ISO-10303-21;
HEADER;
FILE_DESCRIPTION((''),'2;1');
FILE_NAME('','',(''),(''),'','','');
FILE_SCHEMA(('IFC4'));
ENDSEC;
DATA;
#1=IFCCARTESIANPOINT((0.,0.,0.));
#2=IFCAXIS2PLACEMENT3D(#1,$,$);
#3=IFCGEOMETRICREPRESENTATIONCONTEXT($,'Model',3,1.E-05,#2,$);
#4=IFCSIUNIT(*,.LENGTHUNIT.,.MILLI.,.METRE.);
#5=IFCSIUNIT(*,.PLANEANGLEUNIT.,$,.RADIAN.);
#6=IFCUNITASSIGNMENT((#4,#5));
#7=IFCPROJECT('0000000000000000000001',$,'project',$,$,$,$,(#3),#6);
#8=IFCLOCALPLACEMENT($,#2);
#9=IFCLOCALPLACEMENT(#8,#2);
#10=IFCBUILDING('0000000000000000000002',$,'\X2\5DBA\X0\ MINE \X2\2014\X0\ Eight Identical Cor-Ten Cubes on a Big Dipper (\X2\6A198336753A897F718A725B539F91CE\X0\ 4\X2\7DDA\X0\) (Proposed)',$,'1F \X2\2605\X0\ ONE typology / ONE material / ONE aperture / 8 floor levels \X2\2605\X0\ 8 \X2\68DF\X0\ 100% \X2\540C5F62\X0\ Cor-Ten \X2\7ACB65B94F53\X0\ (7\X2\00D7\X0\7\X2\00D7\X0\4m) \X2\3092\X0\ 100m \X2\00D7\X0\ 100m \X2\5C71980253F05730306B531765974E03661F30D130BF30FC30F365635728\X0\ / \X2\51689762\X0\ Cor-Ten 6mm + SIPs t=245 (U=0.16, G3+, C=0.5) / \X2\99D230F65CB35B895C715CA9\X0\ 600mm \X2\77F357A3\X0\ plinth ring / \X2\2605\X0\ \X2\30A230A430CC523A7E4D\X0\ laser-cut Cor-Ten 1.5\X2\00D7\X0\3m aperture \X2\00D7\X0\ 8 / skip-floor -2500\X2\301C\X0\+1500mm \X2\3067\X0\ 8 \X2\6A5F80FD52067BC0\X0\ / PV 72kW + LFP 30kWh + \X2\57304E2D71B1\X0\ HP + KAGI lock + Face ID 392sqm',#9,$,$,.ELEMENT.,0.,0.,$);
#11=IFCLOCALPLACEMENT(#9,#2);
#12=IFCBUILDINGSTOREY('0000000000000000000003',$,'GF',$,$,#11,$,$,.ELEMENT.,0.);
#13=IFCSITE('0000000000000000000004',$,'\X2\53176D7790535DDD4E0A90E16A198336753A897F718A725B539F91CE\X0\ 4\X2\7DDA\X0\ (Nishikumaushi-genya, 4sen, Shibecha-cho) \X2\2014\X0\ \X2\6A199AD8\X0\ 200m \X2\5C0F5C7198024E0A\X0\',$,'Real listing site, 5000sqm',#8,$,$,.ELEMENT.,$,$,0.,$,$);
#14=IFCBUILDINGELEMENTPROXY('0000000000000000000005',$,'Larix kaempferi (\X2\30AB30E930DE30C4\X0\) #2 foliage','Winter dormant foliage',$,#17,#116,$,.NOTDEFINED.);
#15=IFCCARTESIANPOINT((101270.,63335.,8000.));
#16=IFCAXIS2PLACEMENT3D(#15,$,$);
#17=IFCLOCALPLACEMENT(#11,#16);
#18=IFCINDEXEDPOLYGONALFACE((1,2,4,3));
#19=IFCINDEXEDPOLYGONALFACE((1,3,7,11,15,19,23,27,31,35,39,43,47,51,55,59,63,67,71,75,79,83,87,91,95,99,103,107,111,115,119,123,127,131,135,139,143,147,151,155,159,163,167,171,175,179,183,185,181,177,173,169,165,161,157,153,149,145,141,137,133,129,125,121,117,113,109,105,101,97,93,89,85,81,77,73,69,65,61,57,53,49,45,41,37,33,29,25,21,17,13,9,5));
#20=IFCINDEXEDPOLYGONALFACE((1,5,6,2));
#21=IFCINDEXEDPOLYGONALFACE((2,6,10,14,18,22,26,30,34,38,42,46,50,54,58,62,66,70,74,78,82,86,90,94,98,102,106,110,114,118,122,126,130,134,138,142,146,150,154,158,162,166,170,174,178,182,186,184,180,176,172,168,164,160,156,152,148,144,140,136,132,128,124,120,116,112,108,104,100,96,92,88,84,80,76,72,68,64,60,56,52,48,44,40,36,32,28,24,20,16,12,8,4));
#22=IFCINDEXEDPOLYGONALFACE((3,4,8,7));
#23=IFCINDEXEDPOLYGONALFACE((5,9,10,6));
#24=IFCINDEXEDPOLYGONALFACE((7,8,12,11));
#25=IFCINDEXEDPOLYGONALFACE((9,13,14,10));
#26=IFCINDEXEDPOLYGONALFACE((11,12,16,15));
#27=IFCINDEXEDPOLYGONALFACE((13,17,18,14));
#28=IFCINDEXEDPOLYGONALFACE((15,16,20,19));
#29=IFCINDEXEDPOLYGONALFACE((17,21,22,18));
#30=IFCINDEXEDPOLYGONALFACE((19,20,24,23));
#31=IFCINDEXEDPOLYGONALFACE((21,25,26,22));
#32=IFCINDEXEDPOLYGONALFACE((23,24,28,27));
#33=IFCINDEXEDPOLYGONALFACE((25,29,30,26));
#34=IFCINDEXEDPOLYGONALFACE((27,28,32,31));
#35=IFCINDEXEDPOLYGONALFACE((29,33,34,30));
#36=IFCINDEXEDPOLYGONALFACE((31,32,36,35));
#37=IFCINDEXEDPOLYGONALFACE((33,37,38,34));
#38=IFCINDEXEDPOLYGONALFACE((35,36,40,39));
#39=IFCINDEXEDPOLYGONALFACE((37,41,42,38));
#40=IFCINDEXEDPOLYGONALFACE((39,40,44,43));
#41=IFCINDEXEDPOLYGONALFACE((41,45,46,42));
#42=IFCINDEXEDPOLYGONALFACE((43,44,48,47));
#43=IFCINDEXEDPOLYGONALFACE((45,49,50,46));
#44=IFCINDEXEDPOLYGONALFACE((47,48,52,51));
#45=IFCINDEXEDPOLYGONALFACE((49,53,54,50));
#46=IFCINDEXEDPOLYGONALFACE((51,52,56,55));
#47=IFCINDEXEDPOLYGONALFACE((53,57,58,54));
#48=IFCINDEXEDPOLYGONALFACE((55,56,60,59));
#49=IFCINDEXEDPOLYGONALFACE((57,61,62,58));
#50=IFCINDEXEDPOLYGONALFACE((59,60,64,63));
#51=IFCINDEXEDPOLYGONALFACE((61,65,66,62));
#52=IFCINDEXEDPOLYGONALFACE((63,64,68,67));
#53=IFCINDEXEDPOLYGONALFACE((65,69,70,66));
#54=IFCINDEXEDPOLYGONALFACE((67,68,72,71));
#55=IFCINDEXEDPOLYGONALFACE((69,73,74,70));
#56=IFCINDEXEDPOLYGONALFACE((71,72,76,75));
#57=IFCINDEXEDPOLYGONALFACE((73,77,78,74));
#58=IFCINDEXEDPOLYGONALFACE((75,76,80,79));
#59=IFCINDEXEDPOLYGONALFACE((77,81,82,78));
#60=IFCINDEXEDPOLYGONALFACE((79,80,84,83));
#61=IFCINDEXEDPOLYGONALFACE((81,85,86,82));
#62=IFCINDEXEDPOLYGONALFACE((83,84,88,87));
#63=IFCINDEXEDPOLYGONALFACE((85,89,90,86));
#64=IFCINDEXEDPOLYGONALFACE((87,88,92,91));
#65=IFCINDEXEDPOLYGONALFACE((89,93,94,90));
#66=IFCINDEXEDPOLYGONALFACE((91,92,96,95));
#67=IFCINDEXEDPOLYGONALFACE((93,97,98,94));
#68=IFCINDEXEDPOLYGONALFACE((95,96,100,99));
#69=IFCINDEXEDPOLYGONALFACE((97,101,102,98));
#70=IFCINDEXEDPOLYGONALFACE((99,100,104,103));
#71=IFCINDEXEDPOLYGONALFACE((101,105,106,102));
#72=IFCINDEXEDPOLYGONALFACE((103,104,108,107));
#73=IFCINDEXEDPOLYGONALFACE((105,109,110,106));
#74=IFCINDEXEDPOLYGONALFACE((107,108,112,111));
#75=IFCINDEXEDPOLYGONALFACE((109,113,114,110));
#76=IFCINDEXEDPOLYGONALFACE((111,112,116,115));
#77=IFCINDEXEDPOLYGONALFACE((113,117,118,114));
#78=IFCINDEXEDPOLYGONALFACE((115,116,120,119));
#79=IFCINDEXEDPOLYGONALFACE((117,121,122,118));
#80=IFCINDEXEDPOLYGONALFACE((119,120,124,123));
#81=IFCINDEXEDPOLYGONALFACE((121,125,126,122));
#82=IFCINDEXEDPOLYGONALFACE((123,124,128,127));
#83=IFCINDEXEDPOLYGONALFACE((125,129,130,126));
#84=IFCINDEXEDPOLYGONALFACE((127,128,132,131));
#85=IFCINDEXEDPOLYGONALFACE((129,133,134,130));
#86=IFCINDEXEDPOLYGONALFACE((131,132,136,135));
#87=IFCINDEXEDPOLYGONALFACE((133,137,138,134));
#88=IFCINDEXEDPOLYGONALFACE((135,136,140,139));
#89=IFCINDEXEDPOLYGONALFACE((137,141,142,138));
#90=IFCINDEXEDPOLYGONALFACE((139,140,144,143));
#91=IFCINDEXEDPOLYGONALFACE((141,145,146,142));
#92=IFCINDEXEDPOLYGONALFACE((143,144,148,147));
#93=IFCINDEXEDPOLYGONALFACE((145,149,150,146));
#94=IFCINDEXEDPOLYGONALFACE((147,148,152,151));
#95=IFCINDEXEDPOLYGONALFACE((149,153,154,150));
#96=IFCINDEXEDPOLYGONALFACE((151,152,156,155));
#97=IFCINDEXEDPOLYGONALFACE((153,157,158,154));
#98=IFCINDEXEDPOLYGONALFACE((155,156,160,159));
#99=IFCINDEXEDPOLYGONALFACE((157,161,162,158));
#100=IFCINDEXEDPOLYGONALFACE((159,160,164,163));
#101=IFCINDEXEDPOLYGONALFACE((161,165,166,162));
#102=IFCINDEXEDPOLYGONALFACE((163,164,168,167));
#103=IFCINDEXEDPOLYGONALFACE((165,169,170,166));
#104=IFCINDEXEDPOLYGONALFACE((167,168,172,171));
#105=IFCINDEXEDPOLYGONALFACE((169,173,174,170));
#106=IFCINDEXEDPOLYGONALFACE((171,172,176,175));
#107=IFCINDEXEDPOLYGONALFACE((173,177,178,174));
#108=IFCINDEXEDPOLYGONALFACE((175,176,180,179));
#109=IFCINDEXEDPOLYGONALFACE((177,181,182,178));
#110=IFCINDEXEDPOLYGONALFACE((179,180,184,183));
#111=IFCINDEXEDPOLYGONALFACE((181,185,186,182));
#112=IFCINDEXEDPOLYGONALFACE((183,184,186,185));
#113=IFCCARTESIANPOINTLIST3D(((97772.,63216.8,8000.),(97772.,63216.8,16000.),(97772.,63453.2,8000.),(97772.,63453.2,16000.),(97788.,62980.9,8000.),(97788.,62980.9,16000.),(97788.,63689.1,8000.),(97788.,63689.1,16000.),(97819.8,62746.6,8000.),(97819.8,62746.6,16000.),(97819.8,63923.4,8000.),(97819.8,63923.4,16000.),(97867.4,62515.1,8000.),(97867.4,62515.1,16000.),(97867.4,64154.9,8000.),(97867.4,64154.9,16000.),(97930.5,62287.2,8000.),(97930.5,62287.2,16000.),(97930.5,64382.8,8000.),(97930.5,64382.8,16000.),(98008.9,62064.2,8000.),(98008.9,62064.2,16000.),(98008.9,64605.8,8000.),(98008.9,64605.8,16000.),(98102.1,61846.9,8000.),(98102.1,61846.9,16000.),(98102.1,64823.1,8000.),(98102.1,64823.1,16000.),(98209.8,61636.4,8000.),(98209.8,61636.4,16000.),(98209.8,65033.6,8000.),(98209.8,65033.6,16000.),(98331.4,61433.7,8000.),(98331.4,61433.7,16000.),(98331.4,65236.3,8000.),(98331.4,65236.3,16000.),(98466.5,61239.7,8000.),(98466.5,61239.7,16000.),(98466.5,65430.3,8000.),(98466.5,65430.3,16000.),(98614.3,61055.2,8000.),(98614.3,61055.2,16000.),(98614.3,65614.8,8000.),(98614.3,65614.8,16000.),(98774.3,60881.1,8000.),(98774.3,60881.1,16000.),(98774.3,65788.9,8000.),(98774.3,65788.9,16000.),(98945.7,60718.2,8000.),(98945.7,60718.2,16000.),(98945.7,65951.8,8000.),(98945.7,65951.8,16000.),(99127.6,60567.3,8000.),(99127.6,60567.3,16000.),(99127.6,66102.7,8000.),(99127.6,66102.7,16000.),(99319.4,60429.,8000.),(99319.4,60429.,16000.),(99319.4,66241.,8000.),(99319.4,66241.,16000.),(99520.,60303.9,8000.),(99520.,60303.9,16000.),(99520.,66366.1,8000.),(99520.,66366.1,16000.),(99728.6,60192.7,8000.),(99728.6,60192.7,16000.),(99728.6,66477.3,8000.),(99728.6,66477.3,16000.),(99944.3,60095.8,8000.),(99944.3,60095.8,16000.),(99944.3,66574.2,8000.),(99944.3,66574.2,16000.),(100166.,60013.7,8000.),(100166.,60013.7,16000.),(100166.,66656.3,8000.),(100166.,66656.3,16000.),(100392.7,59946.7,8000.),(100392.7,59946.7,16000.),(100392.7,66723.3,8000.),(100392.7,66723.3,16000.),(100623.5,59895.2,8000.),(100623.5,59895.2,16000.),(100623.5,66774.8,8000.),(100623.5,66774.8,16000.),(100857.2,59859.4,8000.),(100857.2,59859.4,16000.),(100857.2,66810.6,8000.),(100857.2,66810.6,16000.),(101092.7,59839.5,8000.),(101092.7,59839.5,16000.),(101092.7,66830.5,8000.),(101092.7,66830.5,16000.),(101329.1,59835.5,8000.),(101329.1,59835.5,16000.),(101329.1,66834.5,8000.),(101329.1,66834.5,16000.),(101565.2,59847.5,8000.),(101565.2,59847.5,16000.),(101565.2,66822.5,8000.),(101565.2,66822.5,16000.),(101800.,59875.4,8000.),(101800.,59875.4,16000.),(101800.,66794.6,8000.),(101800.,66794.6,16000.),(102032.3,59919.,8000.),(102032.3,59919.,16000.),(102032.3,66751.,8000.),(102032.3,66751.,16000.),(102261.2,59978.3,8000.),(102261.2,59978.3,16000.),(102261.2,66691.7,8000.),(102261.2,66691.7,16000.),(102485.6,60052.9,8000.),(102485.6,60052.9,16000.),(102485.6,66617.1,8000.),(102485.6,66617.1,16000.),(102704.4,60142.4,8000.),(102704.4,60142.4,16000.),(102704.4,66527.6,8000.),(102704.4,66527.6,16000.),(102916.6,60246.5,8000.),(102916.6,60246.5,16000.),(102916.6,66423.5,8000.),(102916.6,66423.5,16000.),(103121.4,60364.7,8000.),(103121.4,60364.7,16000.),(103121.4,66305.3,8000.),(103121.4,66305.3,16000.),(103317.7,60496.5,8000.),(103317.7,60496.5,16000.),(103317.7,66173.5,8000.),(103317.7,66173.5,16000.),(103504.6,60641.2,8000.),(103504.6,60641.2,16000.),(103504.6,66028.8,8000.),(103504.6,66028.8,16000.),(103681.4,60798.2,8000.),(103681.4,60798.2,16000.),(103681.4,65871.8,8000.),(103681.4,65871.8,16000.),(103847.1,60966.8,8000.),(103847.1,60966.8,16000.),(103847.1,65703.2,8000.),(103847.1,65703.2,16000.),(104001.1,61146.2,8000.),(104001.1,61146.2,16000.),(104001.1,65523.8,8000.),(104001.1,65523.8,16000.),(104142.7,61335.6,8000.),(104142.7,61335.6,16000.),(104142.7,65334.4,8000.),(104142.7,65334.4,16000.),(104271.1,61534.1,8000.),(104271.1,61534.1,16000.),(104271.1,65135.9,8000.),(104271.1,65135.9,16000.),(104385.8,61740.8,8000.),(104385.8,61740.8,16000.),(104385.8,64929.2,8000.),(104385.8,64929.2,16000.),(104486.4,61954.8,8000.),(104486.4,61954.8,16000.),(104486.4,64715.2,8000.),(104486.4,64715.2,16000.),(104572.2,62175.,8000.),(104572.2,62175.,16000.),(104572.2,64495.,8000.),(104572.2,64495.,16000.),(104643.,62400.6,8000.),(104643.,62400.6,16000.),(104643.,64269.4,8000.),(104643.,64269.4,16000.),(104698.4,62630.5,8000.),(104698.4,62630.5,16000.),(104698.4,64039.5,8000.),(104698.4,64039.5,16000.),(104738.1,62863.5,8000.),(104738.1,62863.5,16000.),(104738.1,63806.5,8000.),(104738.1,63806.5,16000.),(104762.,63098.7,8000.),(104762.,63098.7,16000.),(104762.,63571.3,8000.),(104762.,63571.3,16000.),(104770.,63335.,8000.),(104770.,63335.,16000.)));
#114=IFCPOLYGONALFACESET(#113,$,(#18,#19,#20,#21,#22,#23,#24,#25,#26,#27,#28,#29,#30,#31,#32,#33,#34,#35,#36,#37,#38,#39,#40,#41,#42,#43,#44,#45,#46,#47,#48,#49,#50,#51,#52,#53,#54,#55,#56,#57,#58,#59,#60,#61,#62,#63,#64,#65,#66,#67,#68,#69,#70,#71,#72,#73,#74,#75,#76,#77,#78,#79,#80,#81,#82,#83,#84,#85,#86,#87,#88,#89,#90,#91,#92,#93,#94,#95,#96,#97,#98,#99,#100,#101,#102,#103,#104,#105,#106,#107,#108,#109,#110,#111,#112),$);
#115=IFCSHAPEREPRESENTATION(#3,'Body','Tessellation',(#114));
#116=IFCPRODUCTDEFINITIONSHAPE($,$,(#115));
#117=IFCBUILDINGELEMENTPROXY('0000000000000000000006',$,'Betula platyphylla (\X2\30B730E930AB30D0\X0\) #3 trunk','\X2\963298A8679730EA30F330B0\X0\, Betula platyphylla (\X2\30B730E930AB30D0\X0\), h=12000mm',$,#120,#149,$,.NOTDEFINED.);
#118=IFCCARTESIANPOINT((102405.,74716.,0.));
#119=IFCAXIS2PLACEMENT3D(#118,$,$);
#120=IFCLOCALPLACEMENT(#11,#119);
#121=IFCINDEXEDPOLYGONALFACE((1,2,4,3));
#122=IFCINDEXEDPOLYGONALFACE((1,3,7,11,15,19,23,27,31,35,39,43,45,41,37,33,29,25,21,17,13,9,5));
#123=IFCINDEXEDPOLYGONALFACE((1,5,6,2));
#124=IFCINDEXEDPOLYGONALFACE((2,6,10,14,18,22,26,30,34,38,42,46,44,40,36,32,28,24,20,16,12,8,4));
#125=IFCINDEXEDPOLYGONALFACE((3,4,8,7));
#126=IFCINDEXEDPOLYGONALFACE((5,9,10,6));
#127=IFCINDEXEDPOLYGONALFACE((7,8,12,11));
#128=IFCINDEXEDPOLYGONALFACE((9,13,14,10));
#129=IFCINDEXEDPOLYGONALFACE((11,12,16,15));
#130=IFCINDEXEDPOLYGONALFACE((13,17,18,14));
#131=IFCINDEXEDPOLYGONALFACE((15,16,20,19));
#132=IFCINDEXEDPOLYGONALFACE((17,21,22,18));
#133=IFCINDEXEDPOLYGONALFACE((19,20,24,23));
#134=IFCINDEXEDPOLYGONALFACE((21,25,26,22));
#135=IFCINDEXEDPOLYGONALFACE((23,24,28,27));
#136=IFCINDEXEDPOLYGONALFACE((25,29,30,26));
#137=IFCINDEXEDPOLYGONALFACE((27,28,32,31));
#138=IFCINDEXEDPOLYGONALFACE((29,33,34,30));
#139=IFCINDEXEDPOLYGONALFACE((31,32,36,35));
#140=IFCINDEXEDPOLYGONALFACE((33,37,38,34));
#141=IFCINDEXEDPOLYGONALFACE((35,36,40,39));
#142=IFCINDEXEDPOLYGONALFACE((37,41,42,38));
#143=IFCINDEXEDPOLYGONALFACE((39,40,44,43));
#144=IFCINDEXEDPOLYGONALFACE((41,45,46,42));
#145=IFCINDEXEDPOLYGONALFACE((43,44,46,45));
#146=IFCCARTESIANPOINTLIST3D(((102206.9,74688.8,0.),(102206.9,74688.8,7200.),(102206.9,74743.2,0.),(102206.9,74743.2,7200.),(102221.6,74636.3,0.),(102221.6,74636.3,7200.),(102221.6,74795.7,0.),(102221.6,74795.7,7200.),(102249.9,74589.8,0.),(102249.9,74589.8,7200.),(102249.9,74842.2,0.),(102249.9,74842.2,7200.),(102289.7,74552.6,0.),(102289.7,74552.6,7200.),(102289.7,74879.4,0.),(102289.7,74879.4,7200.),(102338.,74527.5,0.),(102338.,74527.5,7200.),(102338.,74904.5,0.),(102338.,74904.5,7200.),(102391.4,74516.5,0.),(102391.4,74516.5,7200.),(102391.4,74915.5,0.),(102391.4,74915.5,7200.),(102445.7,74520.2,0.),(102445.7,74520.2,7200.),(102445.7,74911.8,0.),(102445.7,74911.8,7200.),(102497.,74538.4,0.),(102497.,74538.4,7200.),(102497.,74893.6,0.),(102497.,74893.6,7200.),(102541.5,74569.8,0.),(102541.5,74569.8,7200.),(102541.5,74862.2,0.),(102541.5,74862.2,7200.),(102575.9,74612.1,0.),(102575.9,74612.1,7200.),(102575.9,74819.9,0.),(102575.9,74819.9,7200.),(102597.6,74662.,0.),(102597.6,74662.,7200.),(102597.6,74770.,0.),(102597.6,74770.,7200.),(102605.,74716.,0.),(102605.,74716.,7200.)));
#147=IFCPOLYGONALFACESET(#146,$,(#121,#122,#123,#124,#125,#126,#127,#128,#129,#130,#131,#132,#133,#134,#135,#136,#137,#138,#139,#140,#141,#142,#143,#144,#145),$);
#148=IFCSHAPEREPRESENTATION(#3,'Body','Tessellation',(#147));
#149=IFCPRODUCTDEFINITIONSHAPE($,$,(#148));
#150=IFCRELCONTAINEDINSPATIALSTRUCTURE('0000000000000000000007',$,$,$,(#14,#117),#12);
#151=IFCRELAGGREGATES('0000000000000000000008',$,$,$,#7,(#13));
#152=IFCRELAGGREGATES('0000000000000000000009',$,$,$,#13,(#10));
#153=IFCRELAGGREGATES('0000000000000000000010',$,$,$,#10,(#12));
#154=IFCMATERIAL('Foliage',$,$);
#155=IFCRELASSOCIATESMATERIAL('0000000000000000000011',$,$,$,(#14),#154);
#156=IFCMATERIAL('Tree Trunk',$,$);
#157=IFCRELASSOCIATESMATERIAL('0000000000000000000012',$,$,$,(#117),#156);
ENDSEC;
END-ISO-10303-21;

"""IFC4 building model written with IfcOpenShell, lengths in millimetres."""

from ifc_helpers import new_model, si_unit, frame, origin, origin_2d, place, context, project, spatial, circle, extrude, material, element, save


model = new_model("IFC4")

# Units and contexts
model_context = context("Model", 3, precision=1e-05, world=origin())
ifc_project = project(units=[si_unit("LENGTHUNIT", "METRE", prefix="MILLI"), si_unit("PLANEANGLEUNIT", "RADIAN")], contexts=[model_context])

# Site, building, storey
site_placement = place(None, origin())
site = spatial("IfcSite", under=ifc_project, at=site_placement, Name="北海道川上郡標茶町西熊牛原野 4線 (Nishikumaushi-genya, 4sen, Shibecha-cho) — 標高 200m 小山頂上", ObjectType="Real listing site, 5000sqm", CompositionType="ELEMENT", RefElevation=0.0)
building_placement = place(site_placement, origin())
building = spatial("IfcBuilding", under=site, at=building_placement, Name="嶺 MINE — Eight Identical Cor-Ten Cubes on a Big Dipper (標茶町西熊牛原野 4線) (Proposed)", ObjectType="1F ★ ONE typology / ONE material / ONE aperture / 8 floor levels ★ 8 棟 100% 同形 Cor-Ten 立方体 (7×7×4m) を 100m × 100m 山頂台地に北斗七星パターン散在 / 全面 Cor-Ten 6mm + SIPs t=245 (U=0.16, G3+, C=0.5) / 駒ヶ岳安山岩 600mm 石垣 plinth ring / ★ アイヌ刺繍 laser-cut Cor-Ten 1.5×3m aperture × 8 / skip-floor -2500〜+1500mm で 8 機能分節 / PV 72kW + LFP 30kWh + 地中熱 HP + KAGI lock + Face ID 392sqm", CompositionType="ELEMENT", ElevationOfRefHeight=0.0, ElevationOfTerrain=0.0)
storey_placement = place(building_placement, origin())
storey = spatial("IfcBuildingStorey", under=building, at=storey_placement, Name="GF", CompositionType="ELEMENT", Elevation=0.0)

# Building element proxies
ifc_material_1 = material(Name="Tree Trunk")
ifc_material_2 = material(Name="Foliage")
proxy_1_placement = place(storey_placement, frame((101270.0, 63335.0, 8000.0)))
element("IfcBuildingElementProxy", 1, at=proxy_1_placement, inside=storey, material=ifc_material_2, Name="Larix kaempferi (カラマツ) #2 foliage", Description="Winter dormant foliage", PredefinedType="NOTDEFINED", context=model_context, shape_type="SweptSolid", body=[
    extrude(circle(Radius=3500.0, at=origin_2d()), frame((101270.0, 63335.0, 8000.0)), (0.0, 0.0, 1.0), 8000.0),
])
proxy_2_placement = place(storey_placement, frame((102405.0, 74716.0, 0.0)))
element("IfcBuildingElementProxy", 2, at=proxy_2_placement, inside=storey, material=ifc_material_1, Name="Betula platyphylla (シラカバ) #3 trunk", Description="防風林リング, Betula platyphylla (シラカバ), h=12000mm", PredefinedType="NOTDEFINED", context=model_context, shape_type="SweptSolid", body=[
    extrude(circle(Radius=200.0, at=origin_2d()), frame((102405.0, 74716.0, 0.0)), (0.0, 0.0, 1.0), 7200.0),
])

save(model, "model.ifc")
